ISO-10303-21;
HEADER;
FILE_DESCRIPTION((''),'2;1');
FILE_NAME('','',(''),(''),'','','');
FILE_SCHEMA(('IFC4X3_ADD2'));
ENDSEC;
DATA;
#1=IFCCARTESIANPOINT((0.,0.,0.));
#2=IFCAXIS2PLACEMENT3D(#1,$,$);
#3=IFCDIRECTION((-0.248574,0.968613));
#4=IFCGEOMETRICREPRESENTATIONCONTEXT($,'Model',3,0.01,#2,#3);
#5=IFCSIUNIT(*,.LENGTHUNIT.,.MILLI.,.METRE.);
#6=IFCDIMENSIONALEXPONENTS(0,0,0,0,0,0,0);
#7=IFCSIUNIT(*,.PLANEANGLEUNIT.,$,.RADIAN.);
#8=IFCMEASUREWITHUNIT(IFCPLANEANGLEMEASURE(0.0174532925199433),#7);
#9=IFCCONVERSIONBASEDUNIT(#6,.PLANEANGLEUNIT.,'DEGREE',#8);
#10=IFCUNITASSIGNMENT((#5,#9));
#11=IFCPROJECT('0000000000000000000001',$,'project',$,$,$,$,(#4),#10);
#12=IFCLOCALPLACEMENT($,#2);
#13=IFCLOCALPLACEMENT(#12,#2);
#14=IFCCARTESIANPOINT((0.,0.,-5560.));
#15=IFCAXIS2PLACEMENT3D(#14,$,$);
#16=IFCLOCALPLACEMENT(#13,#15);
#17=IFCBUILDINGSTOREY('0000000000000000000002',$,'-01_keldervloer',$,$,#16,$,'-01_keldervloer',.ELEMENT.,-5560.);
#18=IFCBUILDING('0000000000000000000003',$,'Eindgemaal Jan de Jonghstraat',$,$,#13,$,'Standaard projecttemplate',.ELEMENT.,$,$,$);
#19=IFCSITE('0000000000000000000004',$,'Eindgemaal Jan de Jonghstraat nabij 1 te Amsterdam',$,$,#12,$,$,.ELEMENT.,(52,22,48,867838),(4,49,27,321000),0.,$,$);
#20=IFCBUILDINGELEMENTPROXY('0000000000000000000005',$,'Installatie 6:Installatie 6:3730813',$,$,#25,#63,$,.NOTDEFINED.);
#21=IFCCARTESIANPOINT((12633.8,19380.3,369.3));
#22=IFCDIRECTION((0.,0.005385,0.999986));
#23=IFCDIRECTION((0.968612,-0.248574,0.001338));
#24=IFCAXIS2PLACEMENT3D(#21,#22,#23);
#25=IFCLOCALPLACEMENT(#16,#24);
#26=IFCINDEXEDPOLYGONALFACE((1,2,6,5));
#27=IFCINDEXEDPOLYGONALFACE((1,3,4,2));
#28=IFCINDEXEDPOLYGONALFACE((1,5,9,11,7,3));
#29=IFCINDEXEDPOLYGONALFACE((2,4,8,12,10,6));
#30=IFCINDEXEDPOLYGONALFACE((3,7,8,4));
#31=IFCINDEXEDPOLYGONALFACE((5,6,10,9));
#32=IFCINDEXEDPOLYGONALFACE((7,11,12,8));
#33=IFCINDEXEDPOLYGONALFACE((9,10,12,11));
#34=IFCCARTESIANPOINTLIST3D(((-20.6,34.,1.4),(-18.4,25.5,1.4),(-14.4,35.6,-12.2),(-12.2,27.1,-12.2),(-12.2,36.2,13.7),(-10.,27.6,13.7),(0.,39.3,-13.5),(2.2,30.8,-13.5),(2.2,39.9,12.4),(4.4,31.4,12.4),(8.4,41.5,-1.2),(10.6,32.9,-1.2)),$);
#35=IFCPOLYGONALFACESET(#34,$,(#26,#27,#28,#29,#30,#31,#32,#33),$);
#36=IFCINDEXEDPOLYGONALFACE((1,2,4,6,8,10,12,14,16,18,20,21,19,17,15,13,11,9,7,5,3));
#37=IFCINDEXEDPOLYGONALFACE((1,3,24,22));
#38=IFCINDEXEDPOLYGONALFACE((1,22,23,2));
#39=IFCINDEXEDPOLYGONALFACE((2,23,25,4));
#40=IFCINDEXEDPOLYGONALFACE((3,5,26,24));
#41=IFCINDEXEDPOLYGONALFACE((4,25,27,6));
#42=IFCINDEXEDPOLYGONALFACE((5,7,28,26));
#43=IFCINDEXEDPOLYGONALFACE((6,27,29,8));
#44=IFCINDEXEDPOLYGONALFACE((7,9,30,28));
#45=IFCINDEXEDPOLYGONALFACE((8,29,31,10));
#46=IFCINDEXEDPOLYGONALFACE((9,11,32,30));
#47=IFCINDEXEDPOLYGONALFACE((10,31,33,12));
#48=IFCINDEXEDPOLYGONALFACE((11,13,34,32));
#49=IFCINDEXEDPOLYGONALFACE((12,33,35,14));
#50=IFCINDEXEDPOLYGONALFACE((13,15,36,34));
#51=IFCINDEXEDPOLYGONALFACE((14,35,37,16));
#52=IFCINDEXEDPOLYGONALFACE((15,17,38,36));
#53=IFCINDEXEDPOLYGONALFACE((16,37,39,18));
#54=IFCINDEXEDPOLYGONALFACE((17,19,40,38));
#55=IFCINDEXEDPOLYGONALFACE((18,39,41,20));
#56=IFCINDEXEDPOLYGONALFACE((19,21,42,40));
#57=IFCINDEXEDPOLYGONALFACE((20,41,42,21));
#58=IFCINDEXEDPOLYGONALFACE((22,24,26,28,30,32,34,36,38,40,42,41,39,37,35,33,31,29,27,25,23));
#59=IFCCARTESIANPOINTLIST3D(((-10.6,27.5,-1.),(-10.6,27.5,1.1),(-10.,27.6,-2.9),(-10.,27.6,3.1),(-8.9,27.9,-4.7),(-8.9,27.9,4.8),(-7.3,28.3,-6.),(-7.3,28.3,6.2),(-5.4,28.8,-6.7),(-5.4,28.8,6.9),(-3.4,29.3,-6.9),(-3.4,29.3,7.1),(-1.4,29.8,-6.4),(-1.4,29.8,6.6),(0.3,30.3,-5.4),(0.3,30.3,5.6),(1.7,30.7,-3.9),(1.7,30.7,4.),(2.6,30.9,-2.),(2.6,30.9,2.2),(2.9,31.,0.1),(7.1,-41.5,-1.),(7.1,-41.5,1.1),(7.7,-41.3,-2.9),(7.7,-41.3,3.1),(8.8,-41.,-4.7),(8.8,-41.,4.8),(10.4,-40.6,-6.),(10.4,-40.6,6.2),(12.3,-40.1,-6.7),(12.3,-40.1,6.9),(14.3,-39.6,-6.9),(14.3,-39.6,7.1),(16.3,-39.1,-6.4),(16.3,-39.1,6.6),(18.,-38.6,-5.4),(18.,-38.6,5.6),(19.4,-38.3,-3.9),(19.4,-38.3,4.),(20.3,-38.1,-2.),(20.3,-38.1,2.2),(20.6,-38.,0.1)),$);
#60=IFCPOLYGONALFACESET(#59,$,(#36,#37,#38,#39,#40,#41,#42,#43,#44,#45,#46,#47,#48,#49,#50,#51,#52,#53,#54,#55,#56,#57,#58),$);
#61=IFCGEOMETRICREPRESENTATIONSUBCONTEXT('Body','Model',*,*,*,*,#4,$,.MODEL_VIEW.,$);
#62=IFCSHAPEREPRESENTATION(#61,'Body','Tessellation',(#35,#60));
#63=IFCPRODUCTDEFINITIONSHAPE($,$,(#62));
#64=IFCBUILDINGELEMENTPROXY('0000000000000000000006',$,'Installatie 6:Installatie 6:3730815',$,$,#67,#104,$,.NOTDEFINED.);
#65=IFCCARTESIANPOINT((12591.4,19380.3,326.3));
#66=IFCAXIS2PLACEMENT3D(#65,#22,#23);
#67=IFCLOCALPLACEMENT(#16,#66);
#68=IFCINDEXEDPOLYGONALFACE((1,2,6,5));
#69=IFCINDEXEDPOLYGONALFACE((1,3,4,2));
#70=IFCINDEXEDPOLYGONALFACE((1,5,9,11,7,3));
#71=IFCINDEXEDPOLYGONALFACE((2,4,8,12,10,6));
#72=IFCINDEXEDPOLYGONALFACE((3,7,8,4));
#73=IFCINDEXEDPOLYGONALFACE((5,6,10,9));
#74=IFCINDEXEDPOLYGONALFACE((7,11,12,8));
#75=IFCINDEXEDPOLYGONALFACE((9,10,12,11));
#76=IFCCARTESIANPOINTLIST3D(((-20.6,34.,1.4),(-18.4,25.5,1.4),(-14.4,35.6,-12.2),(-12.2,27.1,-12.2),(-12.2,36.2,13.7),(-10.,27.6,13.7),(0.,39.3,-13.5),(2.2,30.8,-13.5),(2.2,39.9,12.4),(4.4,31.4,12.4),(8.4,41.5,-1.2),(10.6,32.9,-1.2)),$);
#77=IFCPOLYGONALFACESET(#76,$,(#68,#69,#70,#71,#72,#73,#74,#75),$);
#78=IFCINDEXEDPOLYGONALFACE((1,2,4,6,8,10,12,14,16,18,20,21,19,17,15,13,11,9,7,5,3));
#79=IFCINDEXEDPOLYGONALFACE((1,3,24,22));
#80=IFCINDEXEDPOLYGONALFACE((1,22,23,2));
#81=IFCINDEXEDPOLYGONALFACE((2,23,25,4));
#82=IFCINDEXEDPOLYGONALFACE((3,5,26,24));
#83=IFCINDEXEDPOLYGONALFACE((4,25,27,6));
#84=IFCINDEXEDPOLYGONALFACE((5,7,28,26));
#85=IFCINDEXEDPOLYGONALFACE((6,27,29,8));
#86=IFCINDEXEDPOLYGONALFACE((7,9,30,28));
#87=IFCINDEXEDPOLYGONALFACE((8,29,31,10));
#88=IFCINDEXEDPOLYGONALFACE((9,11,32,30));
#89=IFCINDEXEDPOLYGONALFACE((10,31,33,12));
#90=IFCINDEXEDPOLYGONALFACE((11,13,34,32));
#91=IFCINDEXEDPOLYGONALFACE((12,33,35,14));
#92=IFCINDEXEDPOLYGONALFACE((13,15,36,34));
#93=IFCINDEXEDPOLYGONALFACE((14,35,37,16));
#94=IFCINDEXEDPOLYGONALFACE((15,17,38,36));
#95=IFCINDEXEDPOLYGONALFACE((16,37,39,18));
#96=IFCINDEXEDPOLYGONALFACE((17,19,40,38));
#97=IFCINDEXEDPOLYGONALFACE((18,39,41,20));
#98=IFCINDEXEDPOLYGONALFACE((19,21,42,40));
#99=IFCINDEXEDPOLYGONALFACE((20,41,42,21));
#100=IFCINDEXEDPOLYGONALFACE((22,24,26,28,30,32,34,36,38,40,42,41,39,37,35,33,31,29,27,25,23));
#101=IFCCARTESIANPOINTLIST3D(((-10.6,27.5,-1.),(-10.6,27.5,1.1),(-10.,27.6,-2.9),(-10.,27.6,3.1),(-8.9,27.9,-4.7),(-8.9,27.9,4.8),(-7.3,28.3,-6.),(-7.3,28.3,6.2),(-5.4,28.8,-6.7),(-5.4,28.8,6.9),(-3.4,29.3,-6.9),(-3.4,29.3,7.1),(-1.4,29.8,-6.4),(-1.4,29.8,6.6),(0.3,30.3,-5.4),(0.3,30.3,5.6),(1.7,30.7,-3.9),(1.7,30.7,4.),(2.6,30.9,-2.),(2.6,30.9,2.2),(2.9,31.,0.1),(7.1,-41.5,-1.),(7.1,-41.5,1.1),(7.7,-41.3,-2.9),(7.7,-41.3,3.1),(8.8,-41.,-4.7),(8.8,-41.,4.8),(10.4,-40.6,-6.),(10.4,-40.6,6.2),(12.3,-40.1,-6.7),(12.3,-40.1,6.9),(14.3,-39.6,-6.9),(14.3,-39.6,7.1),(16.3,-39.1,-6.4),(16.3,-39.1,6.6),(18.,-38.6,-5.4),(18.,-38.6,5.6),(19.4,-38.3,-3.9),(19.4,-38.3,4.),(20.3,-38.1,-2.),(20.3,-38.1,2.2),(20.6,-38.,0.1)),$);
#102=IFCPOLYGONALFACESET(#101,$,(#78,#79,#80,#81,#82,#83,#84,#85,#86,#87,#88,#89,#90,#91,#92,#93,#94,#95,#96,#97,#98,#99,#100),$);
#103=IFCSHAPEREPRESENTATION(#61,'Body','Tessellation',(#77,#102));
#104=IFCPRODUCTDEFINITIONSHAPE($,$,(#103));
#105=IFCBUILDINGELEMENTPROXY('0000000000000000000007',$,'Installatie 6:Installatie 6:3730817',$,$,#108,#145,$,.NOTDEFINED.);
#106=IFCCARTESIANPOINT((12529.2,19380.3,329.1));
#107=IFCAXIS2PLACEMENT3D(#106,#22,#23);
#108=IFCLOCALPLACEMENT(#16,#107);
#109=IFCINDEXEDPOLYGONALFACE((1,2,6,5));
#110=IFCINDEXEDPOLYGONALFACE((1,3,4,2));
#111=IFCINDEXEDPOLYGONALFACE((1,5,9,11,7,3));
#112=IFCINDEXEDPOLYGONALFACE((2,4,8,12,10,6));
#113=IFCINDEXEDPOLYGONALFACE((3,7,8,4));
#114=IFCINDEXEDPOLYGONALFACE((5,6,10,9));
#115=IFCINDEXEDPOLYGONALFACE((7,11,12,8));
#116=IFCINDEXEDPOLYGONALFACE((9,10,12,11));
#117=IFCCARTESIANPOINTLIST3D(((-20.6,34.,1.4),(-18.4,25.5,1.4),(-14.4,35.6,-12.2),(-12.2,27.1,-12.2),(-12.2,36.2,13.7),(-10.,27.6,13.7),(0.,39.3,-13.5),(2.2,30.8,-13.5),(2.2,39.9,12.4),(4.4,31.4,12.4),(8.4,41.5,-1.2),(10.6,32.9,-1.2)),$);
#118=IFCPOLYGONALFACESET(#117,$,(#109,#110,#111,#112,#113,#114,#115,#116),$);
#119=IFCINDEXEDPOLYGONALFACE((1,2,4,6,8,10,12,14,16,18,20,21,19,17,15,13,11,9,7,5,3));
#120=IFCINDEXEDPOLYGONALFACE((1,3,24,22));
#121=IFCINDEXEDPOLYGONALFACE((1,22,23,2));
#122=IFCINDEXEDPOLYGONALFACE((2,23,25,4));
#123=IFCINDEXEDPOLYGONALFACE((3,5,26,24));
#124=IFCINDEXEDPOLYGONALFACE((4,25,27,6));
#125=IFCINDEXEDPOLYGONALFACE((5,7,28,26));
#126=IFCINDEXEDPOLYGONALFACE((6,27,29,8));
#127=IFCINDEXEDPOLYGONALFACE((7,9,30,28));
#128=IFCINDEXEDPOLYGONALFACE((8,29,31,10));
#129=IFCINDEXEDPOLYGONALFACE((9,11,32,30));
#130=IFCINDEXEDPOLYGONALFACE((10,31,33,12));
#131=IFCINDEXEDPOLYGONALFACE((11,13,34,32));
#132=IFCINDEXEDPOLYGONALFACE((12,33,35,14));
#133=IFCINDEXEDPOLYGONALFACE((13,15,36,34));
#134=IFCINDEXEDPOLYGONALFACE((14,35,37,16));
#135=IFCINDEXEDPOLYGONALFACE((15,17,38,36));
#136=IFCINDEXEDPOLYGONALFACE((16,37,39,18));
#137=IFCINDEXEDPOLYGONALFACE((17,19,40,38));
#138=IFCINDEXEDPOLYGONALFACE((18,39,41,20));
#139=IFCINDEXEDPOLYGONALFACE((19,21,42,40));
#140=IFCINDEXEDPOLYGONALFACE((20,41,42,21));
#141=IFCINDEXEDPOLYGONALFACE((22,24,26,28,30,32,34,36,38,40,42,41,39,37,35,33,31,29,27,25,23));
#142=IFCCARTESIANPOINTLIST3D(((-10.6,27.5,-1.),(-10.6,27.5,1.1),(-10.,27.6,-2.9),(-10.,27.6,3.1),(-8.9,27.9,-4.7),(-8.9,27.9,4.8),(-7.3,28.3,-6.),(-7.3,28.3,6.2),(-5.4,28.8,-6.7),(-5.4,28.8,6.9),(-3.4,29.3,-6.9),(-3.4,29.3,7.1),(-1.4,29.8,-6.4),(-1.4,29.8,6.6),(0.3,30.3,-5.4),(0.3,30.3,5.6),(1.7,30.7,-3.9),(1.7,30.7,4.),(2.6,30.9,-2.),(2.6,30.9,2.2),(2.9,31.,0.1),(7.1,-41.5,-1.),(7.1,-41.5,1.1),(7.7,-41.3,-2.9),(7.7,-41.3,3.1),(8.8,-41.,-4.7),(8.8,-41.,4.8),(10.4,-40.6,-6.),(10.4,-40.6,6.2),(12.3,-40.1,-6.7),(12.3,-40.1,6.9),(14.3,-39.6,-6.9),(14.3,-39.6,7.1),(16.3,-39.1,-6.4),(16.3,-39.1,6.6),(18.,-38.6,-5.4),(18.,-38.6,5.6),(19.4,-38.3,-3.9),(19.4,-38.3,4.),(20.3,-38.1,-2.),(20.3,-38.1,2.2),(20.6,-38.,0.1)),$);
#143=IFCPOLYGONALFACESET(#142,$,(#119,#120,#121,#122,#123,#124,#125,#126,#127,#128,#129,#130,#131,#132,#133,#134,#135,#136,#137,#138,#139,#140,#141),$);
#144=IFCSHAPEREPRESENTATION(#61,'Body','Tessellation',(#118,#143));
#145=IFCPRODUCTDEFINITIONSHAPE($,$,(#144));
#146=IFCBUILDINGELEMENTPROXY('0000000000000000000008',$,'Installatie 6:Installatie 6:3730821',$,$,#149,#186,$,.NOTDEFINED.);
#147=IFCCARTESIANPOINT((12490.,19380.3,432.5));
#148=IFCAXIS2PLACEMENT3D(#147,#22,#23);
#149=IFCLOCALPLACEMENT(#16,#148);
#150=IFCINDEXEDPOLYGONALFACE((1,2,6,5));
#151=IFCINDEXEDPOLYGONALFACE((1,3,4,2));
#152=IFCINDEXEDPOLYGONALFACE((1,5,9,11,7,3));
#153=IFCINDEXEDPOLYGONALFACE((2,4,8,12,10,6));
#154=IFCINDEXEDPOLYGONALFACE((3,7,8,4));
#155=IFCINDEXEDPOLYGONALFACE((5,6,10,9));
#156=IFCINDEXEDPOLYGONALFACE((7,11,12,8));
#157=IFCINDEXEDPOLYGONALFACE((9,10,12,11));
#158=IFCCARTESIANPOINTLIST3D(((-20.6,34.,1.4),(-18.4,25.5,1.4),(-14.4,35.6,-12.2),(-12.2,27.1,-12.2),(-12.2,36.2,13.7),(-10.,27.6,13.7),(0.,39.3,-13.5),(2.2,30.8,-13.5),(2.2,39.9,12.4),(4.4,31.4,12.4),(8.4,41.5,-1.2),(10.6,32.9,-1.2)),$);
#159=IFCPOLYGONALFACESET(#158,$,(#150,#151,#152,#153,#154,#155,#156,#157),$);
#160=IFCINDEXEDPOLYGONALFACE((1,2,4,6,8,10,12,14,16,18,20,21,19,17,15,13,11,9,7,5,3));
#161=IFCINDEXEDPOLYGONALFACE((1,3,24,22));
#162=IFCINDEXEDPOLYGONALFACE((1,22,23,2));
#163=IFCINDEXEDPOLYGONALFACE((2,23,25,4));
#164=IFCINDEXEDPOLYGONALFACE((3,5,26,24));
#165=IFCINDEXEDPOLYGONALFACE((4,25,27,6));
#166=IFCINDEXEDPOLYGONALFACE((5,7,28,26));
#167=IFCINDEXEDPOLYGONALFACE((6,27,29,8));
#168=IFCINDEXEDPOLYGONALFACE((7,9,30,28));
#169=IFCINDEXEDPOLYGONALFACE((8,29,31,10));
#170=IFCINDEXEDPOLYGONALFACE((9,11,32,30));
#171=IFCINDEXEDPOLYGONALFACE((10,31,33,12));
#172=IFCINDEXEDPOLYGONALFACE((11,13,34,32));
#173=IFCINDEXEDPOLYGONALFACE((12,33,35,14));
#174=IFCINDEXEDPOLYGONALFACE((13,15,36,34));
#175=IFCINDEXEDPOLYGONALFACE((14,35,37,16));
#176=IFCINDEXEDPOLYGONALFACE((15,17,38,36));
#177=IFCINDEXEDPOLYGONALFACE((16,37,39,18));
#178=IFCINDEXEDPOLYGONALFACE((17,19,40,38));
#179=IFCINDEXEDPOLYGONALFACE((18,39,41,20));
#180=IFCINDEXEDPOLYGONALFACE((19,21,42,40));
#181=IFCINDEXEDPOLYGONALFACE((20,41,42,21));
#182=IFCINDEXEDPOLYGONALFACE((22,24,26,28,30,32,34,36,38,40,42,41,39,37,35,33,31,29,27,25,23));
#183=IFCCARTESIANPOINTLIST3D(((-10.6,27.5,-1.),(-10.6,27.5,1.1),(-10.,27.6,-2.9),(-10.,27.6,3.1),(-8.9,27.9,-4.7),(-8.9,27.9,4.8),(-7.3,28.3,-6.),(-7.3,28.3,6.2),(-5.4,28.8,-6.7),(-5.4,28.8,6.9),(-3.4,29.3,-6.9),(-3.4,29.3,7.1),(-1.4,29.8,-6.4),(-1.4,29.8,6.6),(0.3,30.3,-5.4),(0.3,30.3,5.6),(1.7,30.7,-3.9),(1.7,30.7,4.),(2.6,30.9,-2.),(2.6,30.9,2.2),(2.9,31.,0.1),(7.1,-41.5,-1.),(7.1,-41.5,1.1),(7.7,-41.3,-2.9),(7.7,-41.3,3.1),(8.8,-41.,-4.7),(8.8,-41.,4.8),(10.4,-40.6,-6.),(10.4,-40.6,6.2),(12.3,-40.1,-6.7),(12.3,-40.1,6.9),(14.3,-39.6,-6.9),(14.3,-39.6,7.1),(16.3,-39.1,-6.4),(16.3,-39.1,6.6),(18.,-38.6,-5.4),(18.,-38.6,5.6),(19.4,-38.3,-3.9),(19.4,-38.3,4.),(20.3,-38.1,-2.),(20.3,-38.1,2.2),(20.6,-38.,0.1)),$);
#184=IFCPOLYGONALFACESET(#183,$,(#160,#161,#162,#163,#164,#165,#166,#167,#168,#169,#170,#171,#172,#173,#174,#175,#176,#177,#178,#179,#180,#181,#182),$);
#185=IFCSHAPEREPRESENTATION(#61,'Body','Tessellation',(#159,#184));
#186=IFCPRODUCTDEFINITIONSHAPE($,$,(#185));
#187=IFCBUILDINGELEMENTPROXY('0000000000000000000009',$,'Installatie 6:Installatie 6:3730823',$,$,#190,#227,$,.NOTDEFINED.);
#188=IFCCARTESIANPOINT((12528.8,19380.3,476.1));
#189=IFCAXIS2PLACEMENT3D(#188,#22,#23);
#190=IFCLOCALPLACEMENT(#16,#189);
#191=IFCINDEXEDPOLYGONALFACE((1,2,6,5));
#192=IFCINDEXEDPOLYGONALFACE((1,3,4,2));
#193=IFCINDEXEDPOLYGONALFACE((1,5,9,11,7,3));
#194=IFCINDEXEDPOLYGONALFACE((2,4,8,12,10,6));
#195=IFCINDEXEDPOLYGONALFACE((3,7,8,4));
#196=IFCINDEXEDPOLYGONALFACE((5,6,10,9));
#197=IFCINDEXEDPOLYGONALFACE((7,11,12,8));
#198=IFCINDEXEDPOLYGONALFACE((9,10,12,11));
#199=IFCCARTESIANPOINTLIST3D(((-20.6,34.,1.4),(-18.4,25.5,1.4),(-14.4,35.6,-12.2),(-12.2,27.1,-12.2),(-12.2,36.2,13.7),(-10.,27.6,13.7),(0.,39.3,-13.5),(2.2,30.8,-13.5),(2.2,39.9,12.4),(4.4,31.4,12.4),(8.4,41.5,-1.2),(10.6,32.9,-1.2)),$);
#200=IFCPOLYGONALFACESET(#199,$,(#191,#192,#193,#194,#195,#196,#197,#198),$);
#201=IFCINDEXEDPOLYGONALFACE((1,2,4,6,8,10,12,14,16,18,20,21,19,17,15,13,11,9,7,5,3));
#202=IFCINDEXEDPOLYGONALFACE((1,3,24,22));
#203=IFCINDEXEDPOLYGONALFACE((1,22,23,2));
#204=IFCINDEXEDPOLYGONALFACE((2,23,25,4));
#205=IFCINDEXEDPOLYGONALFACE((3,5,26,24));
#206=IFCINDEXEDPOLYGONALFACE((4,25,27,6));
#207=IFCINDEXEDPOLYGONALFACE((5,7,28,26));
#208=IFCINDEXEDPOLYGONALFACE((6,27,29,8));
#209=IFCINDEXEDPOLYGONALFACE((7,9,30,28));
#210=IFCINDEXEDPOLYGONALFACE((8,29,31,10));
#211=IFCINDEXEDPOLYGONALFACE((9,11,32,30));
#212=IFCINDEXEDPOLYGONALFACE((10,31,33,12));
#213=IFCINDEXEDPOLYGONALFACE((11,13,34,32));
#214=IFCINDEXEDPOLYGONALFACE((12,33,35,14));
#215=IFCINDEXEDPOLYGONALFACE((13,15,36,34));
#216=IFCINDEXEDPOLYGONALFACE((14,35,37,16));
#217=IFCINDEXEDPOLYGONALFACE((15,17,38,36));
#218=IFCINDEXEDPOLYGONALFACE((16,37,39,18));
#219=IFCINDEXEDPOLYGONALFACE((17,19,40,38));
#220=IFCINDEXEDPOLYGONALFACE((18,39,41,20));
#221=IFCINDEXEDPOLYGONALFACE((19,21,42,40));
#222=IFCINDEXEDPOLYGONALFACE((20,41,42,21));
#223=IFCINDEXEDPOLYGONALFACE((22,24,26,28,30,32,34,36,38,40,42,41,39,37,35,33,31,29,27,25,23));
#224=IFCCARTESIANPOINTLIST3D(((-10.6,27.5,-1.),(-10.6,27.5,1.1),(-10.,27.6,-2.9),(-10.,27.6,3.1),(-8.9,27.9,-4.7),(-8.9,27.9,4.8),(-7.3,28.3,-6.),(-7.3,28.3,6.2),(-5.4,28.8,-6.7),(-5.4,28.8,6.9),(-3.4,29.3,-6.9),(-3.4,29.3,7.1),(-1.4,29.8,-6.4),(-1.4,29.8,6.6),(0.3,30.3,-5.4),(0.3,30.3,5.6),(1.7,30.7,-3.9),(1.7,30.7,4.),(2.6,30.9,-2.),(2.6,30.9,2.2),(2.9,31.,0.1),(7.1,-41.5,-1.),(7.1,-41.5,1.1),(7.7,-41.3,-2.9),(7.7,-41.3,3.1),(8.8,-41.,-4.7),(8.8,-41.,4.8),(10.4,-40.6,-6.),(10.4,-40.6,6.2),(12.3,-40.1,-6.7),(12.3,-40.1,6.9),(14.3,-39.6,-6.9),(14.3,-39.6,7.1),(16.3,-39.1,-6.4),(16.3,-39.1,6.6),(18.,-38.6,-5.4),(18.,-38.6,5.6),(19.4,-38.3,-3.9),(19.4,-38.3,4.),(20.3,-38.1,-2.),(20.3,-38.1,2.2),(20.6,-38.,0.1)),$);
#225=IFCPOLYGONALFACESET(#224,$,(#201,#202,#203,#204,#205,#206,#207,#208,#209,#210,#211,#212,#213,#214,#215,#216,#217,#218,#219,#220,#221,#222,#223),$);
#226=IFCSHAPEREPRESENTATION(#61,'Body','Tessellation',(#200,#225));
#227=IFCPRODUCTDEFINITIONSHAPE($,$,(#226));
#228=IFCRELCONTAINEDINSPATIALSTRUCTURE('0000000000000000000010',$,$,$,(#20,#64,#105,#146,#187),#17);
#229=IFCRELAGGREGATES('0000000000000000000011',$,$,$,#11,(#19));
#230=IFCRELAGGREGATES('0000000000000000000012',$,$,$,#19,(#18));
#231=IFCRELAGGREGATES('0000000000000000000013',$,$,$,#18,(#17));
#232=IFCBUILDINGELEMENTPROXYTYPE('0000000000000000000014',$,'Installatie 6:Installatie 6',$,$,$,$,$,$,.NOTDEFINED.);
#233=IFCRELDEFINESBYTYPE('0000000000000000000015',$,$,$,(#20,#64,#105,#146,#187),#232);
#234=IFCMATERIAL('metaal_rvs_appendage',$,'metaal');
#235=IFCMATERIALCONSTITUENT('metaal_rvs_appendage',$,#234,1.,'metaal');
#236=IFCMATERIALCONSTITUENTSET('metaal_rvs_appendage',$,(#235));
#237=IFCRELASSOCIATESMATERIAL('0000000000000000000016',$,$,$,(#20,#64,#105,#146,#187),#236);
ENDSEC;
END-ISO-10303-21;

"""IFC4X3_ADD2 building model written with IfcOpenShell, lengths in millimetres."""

from ifc_helpers import new_model, entity, si_unit, converted_unit, direction, frame, frame_2d, origin, place, context, subcontext, project, spatial, polyline, circle, outline, extrude, source, transform, mapped, material, constituent, constituent_set, type_object, type_shapes, element, save


model = new_model("IFC4X3_ADD2")

# Units and contexts
model_context = context("Model", 3, precision=0.01, world=origin(), true_north=direction((-0.248574, 0.968613)))
body_context = subcontext(model_context, "Body", "Model", "MODEL_VIEW")
ifc_project = project(units=[si_unit("LENGTHUNIT", "METRE", prefix="MILLI"), converted_unit("PLANEANGLEUNIT", "DEGREE", entity("IfcPlaneAngleMeasure", 0.0174532925199433), si_unit("PLANEANGLEUNIT", "RADIAN"), dimensions=[0, 0, 0, 0, 0, 0, 0])], contexts=[model_context])

# Site, building, storey
site_placement = place(None, origin())
site = spatial("IfcSite", under=ifc_project, at=site_placement, Name="Eindgemaal Jan de Jonghstraat nabij 1 te Amsterdam", CompositionType="ELEMENT", RefLatitude=(52, 22, 48, 867838), RefLongitude=(4, 49, 27, 321000), RefElevation=0.0)
building_placement = place(site_placement, origin())
building = spatial("IfcBuilding", under=site, at=building_placement, Name="Eindgemaal Jan de Jonghstraat", LongName="Standaard projecttemplate", CompositionType="ELEMENT")
storey_placement = place(building_placement, frame((0.0, 0.0, -5560.0)))
storey = spatial("IfcBuildingStorey", under=building, at=storey_placement, Name="-01_keldervloer", LongName="-01_keldervloer", CompositionType="ELEMENT", Elevation=-5560.0)

# Building element proxies
ifc_material_1 = material(Name="metaal_rvs_appendage", Category="metaal")
ifc_constituent_1 = constituent(ifc_material_1, Name="metaal_rvs_appendage", Category="metaal", fraction=1.0)
ifc_constituent_set_1 = constituent_set(constituents=[ifc_constituent_1], Name="metaal_rvs_appendage")
building_element_proxy_type_1 = type_object("IfcBuildingElementProxyType", Name="Installatie 6:Installatie 6", PredefinedType="NOTDEFINED")
shared_shape_1 = source(origin(), body_context, "Body", "SweptSolid", [
    extrude(outline(polyline([(-7.5, -13.0), (7.5, -13.0), (15.0, 0.0), (7.5, 13.0), (-7.5, 13.0), (-15.0, 0.0), (-7.5, -13.0)])), frame((-3.9, 29.2, 0.1), z_axis=(-0.248574, 0.968613, 0.0), x_axis=(-0.555573, -0.142576, -0.819152)), (0.0, 0.0, 1.0), 8.8),
    extrude(circle(Radius=7.0, at=frame_2d((0.0, 0.0), x_axis=(1.0, 0.0))), frame((-3.9, 29.2, 0.1), z_axis=(0.248574, -0.968613, 0.0), x_axis=(0.968613, 0.248574, 0.0)), (0.0, 0.0, 1.0), 71.2),
])
type_shapes(building_element_proxy_type_1, [shared_shape_1])
for number, where, z_axis, x_axis, name in (
    (1, (12633.8, 19380.3, 369.3), (0.0, 0.005385, 0.999986), (0.968612, -0.248574, 0.001338), "Installatie 6:Installatie 6:3730813"),
    (2, (12591.4, 19380.3, 326.3), (0.0, 0.005385, 0.999986), (0.968612, -0.248574, 0.001338), "Installatie 6:Installatie 6:3730815"),
    (3, (12529.2, 19380.3, 329.1), (0.0, 0.005385, 0.999986), (0.968612, -0.248574, 0.001338), "Installatie 6:Installatie 6:3730817"),
    (4, (12490.0, 19380.3, 432.5), (0.0, 0.005385, 0.999986), (0.968612, -0.248574, 0.001338), "Installatie 6:Installatie 6:3730821"),
    (5, (12528.8, 19380.3, 476.1), (0.0, 0.005385, 0.999986), (0.968612, -0.248574, 0.001338), "Installatie 6:Installatie 6:3730823"),
):
    element("IfcBuildingElementProxy", number, at=place(storey_placement, frame(where, z_axis=z_axis, x_axis=x_axis)), inside=storey, type_object=building_element_proxy_type_1, material=ifc_constituent_set_1, Name=name, PredefinedType="NOTDEFINED", context=body_context, shape_type="MappedRepresentation", body=[
        mapped(shared_shape_1, transform((0.0, 0.0, 0.0), scale=1.0)),
    ])

save(model, "model.ifc")
